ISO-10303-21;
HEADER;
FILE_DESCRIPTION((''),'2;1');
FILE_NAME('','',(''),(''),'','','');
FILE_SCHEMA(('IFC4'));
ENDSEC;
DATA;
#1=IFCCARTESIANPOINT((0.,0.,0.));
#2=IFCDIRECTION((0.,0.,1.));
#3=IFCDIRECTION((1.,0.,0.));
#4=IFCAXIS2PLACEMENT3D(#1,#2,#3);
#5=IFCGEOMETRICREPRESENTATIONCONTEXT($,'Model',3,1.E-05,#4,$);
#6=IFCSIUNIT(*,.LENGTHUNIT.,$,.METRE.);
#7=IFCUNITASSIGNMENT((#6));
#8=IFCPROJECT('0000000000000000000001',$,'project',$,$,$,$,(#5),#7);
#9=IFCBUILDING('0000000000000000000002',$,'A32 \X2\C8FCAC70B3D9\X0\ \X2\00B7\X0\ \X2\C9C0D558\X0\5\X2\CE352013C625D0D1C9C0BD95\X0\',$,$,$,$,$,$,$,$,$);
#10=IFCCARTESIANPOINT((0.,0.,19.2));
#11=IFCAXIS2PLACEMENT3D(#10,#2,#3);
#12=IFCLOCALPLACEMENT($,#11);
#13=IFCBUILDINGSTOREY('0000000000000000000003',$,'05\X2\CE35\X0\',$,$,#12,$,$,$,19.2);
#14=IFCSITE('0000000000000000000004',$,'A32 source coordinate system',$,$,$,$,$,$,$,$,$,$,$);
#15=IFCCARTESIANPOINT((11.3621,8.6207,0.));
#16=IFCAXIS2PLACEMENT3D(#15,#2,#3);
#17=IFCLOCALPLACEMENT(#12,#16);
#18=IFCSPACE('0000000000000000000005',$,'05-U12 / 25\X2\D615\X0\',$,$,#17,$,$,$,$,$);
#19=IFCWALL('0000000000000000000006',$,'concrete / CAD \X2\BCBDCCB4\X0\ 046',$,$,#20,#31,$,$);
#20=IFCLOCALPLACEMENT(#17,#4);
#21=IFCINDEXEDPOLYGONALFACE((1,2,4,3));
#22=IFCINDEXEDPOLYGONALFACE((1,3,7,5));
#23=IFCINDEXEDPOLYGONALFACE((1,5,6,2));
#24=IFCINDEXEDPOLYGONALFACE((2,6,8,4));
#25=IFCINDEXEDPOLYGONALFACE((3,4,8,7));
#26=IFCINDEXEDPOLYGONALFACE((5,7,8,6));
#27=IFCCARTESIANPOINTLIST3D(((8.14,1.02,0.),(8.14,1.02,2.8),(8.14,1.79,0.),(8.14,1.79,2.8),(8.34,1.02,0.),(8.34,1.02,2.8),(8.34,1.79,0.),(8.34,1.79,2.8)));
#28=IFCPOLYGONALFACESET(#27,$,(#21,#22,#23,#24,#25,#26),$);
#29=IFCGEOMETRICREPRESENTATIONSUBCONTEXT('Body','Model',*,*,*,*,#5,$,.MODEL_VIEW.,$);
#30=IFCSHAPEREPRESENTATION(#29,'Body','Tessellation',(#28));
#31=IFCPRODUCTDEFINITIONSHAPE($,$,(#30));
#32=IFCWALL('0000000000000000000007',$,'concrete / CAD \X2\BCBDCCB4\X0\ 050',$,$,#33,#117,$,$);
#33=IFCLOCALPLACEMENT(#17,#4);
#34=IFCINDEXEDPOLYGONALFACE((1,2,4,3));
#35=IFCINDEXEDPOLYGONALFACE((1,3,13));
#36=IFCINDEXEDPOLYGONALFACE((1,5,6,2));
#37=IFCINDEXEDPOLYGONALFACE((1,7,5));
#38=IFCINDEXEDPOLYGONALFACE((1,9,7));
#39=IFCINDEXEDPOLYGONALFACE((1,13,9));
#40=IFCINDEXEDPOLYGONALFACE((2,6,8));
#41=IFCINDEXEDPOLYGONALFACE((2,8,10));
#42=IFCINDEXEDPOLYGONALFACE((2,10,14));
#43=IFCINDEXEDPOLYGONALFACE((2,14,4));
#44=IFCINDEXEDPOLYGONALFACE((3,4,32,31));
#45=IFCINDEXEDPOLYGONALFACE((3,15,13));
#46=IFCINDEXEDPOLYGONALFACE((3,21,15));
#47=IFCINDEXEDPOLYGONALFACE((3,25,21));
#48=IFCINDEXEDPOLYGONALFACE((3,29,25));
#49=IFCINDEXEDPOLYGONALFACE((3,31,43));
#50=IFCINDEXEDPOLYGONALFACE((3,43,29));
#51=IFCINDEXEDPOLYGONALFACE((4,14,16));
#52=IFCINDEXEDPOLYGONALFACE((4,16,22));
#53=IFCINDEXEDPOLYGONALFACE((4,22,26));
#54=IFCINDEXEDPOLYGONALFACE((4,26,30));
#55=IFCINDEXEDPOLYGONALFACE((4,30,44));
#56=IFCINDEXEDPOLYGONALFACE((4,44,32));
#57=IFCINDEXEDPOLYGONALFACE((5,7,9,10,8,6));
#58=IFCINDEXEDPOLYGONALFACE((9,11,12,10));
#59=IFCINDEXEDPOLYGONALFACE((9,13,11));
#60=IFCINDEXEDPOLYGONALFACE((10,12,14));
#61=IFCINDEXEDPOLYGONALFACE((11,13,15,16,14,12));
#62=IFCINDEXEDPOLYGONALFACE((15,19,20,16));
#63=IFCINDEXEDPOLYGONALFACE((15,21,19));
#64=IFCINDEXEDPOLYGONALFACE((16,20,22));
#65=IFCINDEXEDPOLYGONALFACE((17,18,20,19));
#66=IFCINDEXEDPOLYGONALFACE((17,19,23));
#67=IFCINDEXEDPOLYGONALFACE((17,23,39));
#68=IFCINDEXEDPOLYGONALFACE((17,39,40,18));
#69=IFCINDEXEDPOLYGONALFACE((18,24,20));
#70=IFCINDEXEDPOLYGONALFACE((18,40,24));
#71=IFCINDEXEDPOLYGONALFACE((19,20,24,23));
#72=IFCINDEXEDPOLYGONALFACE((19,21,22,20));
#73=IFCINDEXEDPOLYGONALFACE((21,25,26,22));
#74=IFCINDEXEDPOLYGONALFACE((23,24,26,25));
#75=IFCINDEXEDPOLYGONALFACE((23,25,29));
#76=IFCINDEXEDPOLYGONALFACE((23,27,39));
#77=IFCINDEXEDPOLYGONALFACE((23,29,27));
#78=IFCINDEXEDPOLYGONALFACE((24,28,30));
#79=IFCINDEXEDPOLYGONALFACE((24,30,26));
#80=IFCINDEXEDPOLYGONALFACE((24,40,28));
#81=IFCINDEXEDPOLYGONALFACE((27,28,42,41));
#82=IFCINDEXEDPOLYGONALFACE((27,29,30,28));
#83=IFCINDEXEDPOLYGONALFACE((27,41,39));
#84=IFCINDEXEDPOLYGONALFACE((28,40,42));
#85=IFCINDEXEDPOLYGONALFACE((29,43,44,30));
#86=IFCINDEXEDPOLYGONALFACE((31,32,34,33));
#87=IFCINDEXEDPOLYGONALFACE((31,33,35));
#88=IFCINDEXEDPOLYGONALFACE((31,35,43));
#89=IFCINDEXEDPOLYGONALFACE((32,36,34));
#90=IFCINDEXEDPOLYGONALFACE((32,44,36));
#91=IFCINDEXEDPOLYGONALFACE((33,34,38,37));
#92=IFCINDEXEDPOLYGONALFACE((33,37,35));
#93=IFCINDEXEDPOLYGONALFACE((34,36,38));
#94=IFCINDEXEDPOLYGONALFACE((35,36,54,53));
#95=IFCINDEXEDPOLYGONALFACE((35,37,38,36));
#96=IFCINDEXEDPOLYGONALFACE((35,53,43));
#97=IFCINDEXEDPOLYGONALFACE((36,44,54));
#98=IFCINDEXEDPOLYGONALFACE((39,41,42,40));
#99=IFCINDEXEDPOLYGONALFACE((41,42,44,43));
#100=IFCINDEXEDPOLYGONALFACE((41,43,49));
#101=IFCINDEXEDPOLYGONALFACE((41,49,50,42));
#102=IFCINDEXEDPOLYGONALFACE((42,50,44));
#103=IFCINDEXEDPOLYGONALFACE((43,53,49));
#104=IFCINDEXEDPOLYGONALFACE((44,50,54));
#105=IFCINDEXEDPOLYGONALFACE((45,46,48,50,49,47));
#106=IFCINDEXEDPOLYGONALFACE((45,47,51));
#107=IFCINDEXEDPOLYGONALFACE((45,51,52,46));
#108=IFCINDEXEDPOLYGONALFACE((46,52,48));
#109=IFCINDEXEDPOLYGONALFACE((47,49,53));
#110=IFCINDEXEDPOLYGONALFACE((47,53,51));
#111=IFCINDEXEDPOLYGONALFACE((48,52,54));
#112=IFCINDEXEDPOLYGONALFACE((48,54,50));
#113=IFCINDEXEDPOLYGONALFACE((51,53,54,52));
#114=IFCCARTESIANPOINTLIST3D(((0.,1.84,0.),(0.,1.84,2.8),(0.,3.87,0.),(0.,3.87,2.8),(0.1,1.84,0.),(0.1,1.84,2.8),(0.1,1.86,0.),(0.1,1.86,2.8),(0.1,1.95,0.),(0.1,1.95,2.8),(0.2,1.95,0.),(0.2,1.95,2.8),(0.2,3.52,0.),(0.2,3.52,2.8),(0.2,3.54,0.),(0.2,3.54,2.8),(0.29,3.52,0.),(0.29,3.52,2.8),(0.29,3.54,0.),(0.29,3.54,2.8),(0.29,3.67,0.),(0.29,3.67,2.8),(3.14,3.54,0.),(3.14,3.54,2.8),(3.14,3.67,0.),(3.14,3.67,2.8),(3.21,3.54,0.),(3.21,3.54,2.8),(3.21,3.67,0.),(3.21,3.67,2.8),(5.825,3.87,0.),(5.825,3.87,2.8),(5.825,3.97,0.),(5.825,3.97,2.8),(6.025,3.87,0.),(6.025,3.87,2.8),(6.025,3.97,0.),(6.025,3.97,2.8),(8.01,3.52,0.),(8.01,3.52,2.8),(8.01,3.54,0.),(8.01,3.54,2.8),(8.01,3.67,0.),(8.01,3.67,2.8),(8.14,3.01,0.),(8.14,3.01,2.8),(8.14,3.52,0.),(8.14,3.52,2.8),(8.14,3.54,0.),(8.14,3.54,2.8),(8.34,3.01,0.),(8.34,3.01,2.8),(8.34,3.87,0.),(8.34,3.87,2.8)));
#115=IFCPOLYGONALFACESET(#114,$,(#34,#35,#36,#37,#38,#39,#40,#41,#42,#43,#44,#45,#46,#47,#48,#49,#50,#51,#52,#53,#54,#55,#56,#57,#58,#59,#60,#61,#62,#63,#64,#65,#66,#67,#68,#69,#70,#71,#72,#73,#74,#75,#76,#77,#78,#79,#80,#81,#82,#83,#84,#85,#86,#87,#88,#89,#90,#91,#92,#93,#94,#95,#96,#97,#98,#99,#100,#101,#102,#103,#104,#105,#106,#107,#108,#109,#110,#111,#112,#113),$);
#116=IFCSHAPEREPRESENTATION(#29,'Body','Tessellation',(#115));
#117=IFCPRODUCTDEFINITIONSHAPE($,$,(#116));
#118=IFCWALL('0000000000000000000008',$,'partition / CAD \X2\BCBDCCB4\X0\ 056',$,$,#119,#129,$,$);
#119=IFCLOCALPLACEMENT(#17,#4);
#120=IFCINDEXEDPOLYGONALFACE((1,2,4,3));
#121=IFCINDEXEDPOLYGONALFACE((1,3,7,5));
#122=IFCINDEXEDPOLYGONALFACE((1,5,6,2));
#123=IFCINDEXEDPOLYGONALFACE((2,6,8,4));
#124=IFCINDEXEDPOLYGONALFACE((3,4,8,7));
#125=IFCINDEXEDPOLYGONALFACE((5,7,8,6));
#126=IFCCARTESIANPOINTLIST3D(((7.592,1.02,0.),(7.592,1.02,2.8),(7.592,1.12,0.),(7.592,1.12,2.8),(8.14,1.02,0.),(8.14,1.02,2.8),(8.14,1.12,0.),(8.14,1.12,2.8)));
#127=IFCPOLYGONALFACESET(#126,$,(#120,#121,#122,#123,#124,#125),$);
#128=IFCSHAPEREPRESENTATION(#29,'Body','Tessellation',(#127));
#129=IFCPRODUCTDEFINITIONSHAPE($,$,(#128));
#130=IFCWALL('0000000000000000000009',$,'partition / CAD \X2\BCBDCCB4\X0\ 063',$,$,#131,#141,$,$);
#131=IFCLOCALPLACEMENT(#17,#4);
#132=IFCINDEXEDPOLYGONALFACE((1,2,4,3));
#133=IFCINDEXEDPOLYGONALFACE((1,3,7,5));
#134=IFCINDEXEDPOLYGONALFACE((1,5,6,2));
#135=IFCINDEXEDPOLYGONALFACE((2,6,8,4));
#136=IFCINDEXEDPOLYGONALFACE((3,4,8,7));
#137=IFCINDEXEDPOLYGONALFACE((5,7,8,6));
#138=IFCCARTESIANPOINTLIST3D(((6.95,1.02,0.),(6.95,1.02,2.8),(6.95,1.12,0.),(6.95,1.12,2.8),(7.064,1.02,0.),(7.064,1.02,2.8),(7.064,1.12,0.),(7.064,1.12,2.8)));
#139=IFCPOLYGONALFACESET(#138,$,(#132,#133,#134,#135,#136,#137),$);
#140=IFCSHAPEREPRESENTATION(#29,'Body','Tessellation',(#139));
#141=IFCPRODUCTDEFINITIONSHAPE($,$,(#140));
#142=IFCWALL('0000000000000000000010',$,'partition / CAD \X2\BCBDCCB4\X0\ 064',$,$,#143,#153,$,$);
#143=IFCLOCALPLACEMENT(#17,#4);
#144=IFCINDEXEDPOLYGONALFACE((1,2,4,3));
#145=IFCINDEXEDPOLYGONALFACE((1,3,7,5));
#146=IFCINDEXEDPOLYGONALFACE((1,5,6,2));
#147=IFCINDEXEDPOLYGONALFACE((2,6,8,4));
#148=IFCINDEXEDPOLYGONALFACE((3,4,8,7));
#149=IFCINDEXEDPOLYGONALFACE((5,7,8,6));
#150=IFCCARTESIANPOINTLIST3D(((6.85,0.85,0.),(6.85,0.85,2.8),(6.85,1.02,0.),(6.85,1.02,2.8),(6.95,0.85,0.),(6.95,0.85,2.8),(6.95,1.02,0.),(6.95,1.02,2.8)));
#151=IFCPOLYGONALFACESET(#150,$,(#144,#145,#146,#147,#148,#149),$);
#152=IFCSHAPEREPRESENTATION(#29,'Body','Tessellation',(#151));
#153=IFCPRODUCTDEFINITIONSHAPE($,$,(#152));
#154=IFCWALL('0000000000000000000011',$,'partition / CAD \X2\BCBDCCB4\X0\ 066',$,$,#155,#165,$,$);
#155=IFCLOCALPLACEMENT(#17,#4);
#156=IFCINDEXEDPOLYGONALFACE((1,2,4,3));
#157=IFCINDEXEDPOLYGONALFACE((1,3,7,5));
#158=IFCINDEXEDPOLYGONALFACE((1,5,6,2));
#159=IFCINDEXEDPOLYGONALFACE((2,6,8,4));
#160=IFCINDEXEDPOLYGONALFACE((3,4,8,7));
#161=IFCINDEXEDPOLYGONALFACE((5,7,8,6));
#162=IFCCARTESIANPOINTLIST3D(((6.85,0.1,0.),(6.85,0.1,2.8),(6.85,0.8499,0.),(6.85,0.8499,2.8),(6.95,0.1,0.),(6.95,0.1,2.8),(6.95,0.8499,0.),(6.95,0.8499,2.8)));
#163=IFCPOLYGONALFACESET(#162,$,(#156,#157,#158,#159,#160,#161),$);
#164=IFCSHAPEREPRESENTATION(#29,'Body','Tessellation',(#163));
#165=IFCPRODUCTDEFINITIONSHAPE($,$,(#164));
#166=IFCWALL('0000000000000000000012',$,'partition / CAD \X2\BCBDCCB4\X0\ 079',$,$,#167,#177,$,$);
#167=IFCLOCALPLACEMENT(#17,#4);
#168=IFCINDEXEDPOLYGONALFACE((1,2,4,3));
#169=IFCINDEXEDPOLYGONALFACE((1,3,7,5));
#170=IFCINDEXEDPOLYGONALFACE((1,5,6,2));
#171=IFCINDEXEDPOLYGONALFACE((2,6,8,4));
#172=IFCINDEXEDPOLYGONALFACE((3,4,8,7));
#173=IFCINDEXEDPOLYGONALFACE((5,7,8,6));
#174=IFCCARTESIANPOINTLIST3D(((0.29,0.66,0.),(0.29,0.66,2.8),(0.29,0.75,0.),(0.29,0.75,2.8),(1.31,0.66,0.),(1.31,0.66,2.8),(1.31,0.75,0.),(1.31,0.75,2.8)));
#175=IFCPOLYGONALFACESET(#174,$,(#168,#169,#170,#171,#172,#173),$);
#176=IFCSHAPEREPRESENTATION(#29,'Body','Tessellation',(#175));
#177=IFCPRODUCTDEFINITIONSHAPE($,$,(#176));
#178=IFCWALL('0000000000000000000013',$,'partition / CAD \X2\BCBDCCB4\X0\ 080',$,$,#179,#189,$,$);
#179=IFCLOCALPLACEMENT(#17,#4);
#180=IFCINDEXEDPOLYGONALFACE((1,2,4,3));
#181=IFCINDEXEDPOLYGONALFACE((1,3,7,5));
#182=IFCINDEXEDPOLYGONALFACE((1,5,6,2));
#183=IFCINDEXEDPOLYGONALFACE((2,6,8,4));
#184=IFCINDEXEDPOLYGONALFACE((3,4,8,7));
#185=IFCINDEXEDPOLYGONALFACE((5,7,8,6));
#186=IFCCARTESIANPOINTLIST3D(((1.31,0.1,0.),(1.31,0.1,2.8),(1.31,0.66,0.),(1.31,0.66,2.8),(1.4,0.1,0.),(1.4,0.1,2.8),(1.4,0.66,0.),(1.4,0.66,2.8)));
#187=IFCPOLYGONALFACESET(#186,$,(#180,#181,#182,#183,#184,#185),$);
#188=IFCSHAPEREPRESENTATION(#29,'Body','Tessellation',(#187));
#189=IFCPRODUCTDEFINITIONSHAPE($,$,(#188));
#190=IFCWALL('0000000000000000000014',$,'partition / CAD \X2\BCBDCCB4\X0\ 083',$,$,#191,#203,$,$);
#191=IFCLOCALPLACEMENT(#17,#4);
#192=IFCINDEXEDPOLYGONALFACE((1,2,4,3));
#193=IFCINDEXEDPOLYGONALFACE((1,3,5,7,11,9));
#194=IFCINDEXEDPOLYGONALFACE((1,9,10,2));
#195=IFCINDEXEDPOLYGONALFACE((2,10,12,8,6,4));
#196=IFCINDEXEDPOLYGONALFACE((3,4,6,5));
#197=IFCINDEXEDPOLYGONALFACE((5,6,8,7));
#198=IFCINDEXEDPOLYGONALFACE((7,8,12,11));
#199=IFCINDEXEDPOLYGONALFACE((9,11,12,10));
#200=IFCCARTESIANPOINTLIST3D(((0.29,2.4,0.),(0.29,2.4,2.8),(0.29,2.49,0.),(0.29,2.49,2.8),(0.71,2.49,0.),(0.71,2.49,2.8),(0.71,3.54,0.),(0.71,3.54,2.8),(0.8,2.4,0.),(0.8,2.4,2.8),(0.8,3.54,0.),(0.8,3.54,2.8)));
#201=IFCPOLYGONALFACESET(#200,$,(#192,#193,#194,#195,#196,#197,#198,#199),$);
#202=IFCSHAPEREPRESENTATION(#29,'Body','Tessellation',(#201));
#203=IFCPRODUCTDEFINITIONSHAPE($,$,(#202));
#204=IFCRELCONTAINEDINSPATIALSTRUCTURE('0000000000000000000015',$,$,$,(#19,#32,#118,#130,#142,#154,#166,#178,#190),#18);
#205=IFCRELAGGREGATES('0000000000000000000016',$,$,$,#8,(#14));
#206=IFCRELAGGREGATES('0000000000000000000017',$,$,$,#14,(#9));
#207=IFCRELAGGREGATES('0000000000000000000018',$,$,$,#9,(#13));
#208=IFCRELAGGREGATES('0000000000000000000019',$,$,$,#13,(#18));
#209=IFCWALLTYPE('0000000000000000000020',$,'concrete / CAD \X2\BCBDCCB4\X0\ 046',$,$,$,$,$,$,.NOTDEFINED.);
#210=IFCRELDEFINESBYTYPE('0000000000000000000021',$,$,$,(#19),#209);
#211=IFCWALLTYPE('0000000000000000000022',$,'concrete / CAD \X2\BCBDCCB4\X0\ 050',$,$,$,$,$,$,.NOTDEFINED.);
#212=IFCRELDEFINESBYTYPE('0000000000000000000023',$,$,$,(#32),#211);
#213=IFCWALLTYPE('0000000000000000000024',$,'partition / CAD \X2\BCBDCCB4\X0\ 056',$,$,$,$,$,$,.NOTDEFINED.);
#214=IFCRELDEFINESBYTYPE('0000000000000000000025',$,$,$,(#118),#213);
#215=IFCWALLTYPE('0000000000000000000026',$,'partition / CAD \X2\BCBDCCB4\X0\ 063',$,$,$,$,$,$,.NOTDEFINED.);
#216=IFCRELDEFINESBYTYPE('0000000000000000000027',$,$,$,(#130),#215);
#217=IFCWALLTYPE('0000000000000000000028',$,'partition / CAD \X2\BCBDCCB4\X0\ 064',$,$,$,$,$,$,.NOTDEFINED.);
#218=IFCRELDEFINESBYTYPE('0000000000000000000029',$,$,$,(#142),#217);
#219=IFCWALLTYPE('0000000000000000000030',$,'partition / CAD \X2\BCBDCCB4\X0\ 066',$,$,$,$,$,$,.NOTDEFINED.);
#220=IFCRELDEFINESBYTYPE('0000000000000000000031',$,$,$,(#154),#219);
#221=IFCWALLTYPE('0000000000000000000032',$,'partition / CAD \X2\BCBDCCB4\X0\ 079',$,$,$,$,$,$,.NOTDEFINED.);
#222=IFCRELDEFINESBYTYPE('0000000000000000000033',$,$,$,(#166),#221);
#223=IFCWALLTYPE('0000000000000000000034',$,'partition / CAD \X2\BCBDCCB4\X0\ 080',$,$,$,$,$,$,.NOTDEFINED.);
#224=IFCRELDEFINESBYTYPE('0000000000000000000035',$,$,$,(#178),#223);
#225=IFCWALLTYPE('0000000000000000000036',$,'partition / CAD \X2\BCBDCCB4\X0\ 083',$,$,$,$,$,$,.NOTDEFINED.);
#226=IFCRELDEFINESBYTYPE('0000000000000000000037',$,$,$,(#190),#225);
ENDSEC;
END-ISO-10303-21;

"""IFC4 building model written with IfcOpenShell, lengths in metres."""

from ifc_helpers import new_model, si_unit, frame, origin, origin_with_axes, place, context, subcontext, project, spatial, polyline, outline, extrude, source, transform, mapped, type_object, type_shapes, element, save


model = new_model("IFC4")

# Units and contexts
model_context = context("Model", 3, precision=1e-05, world=origin_with_axes())
body_context = subcontext(model_context, "Body", "Model", "MODEL_VIEW")
ifc_project = project(units=[si_unit("LENGTHUNIT", "METRE")], contexts=[model_context])

# Site, building, storey, space
site = spatial("IfcSite", under=ifc_project, Name="A32 source coordinate system")
building = spatial("IfcBuilding", under=site, Name="A32 주거동 · 지하5층–옥탑지붕")
storey_placement = place(None, frame((0.0, 0.0, 19.2), z_axis=(0.0, 0.0, 1.0), x_axis=(1.0, 0.0, 0.0)))
storey = spatial("IfcBuildingStorey", under=building, at=storey_placement, Name="05층", Elevation=19.2)
space_1_placement = place(storey_placement, frame((11.3621, 8.6207, 0.0), z_axis=(0.0, 0.0, 1.0), x_axis=(1.0, 0.0, 0.0)))
space_1 = spatial("IfcSpace", under=storey, at=space_1_placement, Name="05-U12 / 25형")

# Walls
wall_type_1 = type_object("IfcWallType", Name="concrete / CAD 벽체 046", PredefinedType="NOTDEFINED")
shared_shape_1 = source(origin(), body_context, "Body", "SweptSolid", [
    extrude(outline(polyline([(8.14, 1.02), (8.14, 1.79), (8.34, 1.79), (8.34, 1.02), (8.14, 1.02)])), origin(), (0.0, 0.0, 1.0), 2.8),
])
type_shapes(wall_type_1, [shared_shape_1])
wall_1_placement = place(space_1_placement, origin_with_axes())
element("IfcWall", 1, at=wall_1_placement, inside=space_1, type_object=wall_type_1, Name="concrete / CAD 벽체 046", context=body_context, shape_type="MappedRepresentation", body=[
    mapped(shared_shape_1, transform((0.0, 0.0, 0.0), scale=1.0)),
])
wall_type_2 = type_object("IfcWallType", Name="concrete / CAD 벽체 050", PredefinedType="NOTDEFINED")
shared_shape_2 = source(origin(), body_context, "Body", "SweptSolid", [
    extrude(outline(polyline([(8.01, 3.52), (0.29, 3.52), (0.29, 3.54), (0.2, 3.54), (0.2, 3.52), (0.2, 1.95), (0.1, 1.95), (0.1, 1.86), (0.1, 1.84), (0.0, 1.84), (0.0, 3.87), (5.825, 3.87), (5.825, 3.97), (6.025, 3.97), (6.025, 3.87), (8.34, 3.87), (8.34, 3.01), (8.14, 3.01), (8.14, 3.52), (8.14, 3.54), (8.01, 3.54), (8.01, 3.52)]), holes=[polyline([(3.14, 3.54), (3.14, 3.67), (0.29, 3.67), (0.29, 3.54), (3.14, 3.54)]), polyline([(8.01, 3.67), (3.21, 3.67), (3.21, 3.54), (8.01, 3.54), (8.01, 3.67)])]), origin(), (0.0, 0.0, 1.0), 2.8),
])
type_shapes(wall_type_2, [shared_shape_2])
wall_2_placement = place(space_1_placement, origin_with_axes())
element("IfcWall", 2, at=wall_2_placement, inside=space_1, type_object=wall_type_2, Name="concrete / CAD 벽체 050", context=body_context, shape_type="MappedRepresentation", body=[
    mapped(shared_shape_2, transform((0.0, 0.0, 0.0), scale=1.0)),
])
wall_type_3 = type_object("IfcWallType", Name="partition / CAD 벽체 056", PredefinedType="NOTDEFINED")
shared_shape_3 = source(origin(), body_context, "Body", "SweptSolid", [
    extrude(outline(polyline([(7.592, 1.12), (8.14, 1.12), (8.14, 1.02), (7.592, 1.02), (7.592, 1.12)])), origin(), (0.0, 0.0, 1.0), 2.8),
])
type_shapes(wall_type_3, [shared_shape_3])
wall_3_placement = place(space_1_placement, origin_with_axes())
element("IfcWall", 3, at=wall_3_placement, inside=space_1, type_object=wall_type_3, Name="partition / CAD 벽체 056", context=body_context, shape_type="MappedRepresentation", body=[
    mapped(shared_shape_3, transform((0.0, 0.0, 0.0), scale=1.0)),
])
wall_type_4 = type_object("IfcWallType", Name="partition / CAD 벽체 063", PredefinedType="NOTDEFINED")
shared_shape_4 = source(origin(), body_context, "Body", "SweptSolid", [
    extrude(outline(polyline([(6.95, 1.12), (7.064, 1.12), (7.064, 1.02), (6.95, 1.02), (6.95, 1.12)])), origin(), (0.0, 0.0, 1.0), 2.8),
])
type_shapes(wall_type_4, [shared_shape_4])
wall_4_placement = place(space_1_placement, origin_with_axes())
element("IfcWall", 4, at=wall_4_placement, inside=space_1, type_object=wall_type_4, Name="partition / CAD 벽체 063", context=body_context, shape_type="MappedRepresentation", body=[
    mapped(shared_shape_4, transform((0.0, 0.0, 0.0), scale=1.0)),
])
wall_type_5 = type_object("IfcWallType", Name="partition / CAD 벽체 064", PredefinedType="NOTDEFINED")
shared_shape_5 = source(origin(), body_context, "Body", "SweptSolid", [
    extrude(outline(polyline([(6.95, 0.85), (6.85, 0.85), (6.85, 1.02), (6.95, 1.02), (6.95, 0.85)])), origin(), (0.0, 0.0, 1.0), 2.8),
])
type_shapes(wall_type_5, [shared_shape_5])
wall_5_placement = place(space_1_placement, origin_with_axes())
element("IfcWall", 5, at=wall_5_placement, inside=space_1, type_object=wall_type_5, Name="partition / CAD 벽체 064", context=body_context, shape_type="MappedRepresentation", body=[
    mapped(shared_shape_5, transform((0.0, 0.0, 0.0), scale=1.0)),
])
wall_type_6 = type_object("IfcWallType", Name="partition / CAD 벽체 066", PredefinedType="NOTDEFINED")
shared_shape_6 = source(origin(), body_context, "Body", "SweptSolid", [
    extrude(outline(polyline([(6.85, 0.8499), (6.95, 0.8499), (6.95, 0.1), (6.85, 0.1), (6.85, 0.8499)])), origin(), (0.0, 0.0, 1.0), 2.8),
])
type_shapes(wall_type_6, [shared_shape_6])
wall_6_placement = place(space_1_placement, origin_with_axes())
element("IfcWall", 6, at=wall_6_placement, inside=space_1, type_object=wall_type_6, Name="partition / CAD 벽체 066", context=body_context, shape_type="MappedRepresentation", body=[
    mapped(shared_shape_6, transform((0.0, 0.0, 0.0), scale=1.0)),
])
wall_type_7 = type_object("IfcWallType", Name="partition / CAD 벽체 079", PredefinedType="NOTDEFINED")
shared_shape_7 = source(origin(), body_context, "Body", "SweptSolid", [
    extrude(outline(polyline([(0.29, 0.75), (1.31, 0.75), (1.31, 0.66), (0.29, 0.66), (0.29, 0.75)])), origin(), (0.0, 0.0, 1.0), 2.8),
])
type_shapes(wall_type_7, [shared_shape_7])
wall_7_placement = place(space_1_placement, origin_with_axes())
element("IfcWall", 7, at=wall_7_placement, inside=space_1, type_object=wall_type_7, Name="partition / CAD 벽체 079", context=body_context, shape_type="MappedRepresentation", body=[
    mapped(shared_shape_7, transform((0.0, 0.0, 0.0), scale=1.0)),
])
wall_type_8 = type_object("IfcWallType", Name="partition / CAD 벽체 080", PredefinedType="NOTDEFINED")
shared_shape_8 = source(origin(), body_context, "Body", "SweptSolid", [
    extrude(outline(polyline([(1.4, 0.66), (1.4, 0.1), (1.31, 0.1), (1.31, 0.66), (1.4, 0.66)])), origin(), (0.0, 0.0, 1.0), 2.8),
])
type_shapes(wall_type_8, [shared_shape_8])
wall_8_placement = place(space_1_placement, origin_with_axes())
element("IfcWall", 8, at=wall_8_placement, inside=space_1, type_object=wall_type_8, Name="partition / CAD 벽체 080", context=body_context, shape_type="MappedRepresentation", body=[
    mapped(shared_shape_8, transform((0.0, 0.0, 0.0), scale=1.0)),
])
wall_type_9 = type_object("IfcWallType", Name="partition / CAD 벽체 083", PredefinedType="NOTDEFINED")
shared_shape_9 = source(origin(), body_context, "Body", "SweptSolid", [
    extrude(outline(polyline([(0.71, 2.49), (0.71, 3.54), (0.8, 3.54), (0.8, 2.4), (0.29, 2.4), (0.29, 2.49), (0.71, 2.49)])), origin(), (0.0, 0.0, 1.0), 2.8),
])
type_shapes(wall_type_9, [shared_shape_9])
wall_9_placement = place(space_1_placement, origin_with_axes())
element("IfcWall", 9, at=wall_9_placement, inside=space_1, type_object=wall_type_9, Name="partition / CAD 벽체 083", context=body_context, shape_type="MappedRepresentation", body=[
    mapped(shared_shape_9, transform((0.0, 0.0, 0.0), scale=1.0)),
])

save(model, "model.ifc")
